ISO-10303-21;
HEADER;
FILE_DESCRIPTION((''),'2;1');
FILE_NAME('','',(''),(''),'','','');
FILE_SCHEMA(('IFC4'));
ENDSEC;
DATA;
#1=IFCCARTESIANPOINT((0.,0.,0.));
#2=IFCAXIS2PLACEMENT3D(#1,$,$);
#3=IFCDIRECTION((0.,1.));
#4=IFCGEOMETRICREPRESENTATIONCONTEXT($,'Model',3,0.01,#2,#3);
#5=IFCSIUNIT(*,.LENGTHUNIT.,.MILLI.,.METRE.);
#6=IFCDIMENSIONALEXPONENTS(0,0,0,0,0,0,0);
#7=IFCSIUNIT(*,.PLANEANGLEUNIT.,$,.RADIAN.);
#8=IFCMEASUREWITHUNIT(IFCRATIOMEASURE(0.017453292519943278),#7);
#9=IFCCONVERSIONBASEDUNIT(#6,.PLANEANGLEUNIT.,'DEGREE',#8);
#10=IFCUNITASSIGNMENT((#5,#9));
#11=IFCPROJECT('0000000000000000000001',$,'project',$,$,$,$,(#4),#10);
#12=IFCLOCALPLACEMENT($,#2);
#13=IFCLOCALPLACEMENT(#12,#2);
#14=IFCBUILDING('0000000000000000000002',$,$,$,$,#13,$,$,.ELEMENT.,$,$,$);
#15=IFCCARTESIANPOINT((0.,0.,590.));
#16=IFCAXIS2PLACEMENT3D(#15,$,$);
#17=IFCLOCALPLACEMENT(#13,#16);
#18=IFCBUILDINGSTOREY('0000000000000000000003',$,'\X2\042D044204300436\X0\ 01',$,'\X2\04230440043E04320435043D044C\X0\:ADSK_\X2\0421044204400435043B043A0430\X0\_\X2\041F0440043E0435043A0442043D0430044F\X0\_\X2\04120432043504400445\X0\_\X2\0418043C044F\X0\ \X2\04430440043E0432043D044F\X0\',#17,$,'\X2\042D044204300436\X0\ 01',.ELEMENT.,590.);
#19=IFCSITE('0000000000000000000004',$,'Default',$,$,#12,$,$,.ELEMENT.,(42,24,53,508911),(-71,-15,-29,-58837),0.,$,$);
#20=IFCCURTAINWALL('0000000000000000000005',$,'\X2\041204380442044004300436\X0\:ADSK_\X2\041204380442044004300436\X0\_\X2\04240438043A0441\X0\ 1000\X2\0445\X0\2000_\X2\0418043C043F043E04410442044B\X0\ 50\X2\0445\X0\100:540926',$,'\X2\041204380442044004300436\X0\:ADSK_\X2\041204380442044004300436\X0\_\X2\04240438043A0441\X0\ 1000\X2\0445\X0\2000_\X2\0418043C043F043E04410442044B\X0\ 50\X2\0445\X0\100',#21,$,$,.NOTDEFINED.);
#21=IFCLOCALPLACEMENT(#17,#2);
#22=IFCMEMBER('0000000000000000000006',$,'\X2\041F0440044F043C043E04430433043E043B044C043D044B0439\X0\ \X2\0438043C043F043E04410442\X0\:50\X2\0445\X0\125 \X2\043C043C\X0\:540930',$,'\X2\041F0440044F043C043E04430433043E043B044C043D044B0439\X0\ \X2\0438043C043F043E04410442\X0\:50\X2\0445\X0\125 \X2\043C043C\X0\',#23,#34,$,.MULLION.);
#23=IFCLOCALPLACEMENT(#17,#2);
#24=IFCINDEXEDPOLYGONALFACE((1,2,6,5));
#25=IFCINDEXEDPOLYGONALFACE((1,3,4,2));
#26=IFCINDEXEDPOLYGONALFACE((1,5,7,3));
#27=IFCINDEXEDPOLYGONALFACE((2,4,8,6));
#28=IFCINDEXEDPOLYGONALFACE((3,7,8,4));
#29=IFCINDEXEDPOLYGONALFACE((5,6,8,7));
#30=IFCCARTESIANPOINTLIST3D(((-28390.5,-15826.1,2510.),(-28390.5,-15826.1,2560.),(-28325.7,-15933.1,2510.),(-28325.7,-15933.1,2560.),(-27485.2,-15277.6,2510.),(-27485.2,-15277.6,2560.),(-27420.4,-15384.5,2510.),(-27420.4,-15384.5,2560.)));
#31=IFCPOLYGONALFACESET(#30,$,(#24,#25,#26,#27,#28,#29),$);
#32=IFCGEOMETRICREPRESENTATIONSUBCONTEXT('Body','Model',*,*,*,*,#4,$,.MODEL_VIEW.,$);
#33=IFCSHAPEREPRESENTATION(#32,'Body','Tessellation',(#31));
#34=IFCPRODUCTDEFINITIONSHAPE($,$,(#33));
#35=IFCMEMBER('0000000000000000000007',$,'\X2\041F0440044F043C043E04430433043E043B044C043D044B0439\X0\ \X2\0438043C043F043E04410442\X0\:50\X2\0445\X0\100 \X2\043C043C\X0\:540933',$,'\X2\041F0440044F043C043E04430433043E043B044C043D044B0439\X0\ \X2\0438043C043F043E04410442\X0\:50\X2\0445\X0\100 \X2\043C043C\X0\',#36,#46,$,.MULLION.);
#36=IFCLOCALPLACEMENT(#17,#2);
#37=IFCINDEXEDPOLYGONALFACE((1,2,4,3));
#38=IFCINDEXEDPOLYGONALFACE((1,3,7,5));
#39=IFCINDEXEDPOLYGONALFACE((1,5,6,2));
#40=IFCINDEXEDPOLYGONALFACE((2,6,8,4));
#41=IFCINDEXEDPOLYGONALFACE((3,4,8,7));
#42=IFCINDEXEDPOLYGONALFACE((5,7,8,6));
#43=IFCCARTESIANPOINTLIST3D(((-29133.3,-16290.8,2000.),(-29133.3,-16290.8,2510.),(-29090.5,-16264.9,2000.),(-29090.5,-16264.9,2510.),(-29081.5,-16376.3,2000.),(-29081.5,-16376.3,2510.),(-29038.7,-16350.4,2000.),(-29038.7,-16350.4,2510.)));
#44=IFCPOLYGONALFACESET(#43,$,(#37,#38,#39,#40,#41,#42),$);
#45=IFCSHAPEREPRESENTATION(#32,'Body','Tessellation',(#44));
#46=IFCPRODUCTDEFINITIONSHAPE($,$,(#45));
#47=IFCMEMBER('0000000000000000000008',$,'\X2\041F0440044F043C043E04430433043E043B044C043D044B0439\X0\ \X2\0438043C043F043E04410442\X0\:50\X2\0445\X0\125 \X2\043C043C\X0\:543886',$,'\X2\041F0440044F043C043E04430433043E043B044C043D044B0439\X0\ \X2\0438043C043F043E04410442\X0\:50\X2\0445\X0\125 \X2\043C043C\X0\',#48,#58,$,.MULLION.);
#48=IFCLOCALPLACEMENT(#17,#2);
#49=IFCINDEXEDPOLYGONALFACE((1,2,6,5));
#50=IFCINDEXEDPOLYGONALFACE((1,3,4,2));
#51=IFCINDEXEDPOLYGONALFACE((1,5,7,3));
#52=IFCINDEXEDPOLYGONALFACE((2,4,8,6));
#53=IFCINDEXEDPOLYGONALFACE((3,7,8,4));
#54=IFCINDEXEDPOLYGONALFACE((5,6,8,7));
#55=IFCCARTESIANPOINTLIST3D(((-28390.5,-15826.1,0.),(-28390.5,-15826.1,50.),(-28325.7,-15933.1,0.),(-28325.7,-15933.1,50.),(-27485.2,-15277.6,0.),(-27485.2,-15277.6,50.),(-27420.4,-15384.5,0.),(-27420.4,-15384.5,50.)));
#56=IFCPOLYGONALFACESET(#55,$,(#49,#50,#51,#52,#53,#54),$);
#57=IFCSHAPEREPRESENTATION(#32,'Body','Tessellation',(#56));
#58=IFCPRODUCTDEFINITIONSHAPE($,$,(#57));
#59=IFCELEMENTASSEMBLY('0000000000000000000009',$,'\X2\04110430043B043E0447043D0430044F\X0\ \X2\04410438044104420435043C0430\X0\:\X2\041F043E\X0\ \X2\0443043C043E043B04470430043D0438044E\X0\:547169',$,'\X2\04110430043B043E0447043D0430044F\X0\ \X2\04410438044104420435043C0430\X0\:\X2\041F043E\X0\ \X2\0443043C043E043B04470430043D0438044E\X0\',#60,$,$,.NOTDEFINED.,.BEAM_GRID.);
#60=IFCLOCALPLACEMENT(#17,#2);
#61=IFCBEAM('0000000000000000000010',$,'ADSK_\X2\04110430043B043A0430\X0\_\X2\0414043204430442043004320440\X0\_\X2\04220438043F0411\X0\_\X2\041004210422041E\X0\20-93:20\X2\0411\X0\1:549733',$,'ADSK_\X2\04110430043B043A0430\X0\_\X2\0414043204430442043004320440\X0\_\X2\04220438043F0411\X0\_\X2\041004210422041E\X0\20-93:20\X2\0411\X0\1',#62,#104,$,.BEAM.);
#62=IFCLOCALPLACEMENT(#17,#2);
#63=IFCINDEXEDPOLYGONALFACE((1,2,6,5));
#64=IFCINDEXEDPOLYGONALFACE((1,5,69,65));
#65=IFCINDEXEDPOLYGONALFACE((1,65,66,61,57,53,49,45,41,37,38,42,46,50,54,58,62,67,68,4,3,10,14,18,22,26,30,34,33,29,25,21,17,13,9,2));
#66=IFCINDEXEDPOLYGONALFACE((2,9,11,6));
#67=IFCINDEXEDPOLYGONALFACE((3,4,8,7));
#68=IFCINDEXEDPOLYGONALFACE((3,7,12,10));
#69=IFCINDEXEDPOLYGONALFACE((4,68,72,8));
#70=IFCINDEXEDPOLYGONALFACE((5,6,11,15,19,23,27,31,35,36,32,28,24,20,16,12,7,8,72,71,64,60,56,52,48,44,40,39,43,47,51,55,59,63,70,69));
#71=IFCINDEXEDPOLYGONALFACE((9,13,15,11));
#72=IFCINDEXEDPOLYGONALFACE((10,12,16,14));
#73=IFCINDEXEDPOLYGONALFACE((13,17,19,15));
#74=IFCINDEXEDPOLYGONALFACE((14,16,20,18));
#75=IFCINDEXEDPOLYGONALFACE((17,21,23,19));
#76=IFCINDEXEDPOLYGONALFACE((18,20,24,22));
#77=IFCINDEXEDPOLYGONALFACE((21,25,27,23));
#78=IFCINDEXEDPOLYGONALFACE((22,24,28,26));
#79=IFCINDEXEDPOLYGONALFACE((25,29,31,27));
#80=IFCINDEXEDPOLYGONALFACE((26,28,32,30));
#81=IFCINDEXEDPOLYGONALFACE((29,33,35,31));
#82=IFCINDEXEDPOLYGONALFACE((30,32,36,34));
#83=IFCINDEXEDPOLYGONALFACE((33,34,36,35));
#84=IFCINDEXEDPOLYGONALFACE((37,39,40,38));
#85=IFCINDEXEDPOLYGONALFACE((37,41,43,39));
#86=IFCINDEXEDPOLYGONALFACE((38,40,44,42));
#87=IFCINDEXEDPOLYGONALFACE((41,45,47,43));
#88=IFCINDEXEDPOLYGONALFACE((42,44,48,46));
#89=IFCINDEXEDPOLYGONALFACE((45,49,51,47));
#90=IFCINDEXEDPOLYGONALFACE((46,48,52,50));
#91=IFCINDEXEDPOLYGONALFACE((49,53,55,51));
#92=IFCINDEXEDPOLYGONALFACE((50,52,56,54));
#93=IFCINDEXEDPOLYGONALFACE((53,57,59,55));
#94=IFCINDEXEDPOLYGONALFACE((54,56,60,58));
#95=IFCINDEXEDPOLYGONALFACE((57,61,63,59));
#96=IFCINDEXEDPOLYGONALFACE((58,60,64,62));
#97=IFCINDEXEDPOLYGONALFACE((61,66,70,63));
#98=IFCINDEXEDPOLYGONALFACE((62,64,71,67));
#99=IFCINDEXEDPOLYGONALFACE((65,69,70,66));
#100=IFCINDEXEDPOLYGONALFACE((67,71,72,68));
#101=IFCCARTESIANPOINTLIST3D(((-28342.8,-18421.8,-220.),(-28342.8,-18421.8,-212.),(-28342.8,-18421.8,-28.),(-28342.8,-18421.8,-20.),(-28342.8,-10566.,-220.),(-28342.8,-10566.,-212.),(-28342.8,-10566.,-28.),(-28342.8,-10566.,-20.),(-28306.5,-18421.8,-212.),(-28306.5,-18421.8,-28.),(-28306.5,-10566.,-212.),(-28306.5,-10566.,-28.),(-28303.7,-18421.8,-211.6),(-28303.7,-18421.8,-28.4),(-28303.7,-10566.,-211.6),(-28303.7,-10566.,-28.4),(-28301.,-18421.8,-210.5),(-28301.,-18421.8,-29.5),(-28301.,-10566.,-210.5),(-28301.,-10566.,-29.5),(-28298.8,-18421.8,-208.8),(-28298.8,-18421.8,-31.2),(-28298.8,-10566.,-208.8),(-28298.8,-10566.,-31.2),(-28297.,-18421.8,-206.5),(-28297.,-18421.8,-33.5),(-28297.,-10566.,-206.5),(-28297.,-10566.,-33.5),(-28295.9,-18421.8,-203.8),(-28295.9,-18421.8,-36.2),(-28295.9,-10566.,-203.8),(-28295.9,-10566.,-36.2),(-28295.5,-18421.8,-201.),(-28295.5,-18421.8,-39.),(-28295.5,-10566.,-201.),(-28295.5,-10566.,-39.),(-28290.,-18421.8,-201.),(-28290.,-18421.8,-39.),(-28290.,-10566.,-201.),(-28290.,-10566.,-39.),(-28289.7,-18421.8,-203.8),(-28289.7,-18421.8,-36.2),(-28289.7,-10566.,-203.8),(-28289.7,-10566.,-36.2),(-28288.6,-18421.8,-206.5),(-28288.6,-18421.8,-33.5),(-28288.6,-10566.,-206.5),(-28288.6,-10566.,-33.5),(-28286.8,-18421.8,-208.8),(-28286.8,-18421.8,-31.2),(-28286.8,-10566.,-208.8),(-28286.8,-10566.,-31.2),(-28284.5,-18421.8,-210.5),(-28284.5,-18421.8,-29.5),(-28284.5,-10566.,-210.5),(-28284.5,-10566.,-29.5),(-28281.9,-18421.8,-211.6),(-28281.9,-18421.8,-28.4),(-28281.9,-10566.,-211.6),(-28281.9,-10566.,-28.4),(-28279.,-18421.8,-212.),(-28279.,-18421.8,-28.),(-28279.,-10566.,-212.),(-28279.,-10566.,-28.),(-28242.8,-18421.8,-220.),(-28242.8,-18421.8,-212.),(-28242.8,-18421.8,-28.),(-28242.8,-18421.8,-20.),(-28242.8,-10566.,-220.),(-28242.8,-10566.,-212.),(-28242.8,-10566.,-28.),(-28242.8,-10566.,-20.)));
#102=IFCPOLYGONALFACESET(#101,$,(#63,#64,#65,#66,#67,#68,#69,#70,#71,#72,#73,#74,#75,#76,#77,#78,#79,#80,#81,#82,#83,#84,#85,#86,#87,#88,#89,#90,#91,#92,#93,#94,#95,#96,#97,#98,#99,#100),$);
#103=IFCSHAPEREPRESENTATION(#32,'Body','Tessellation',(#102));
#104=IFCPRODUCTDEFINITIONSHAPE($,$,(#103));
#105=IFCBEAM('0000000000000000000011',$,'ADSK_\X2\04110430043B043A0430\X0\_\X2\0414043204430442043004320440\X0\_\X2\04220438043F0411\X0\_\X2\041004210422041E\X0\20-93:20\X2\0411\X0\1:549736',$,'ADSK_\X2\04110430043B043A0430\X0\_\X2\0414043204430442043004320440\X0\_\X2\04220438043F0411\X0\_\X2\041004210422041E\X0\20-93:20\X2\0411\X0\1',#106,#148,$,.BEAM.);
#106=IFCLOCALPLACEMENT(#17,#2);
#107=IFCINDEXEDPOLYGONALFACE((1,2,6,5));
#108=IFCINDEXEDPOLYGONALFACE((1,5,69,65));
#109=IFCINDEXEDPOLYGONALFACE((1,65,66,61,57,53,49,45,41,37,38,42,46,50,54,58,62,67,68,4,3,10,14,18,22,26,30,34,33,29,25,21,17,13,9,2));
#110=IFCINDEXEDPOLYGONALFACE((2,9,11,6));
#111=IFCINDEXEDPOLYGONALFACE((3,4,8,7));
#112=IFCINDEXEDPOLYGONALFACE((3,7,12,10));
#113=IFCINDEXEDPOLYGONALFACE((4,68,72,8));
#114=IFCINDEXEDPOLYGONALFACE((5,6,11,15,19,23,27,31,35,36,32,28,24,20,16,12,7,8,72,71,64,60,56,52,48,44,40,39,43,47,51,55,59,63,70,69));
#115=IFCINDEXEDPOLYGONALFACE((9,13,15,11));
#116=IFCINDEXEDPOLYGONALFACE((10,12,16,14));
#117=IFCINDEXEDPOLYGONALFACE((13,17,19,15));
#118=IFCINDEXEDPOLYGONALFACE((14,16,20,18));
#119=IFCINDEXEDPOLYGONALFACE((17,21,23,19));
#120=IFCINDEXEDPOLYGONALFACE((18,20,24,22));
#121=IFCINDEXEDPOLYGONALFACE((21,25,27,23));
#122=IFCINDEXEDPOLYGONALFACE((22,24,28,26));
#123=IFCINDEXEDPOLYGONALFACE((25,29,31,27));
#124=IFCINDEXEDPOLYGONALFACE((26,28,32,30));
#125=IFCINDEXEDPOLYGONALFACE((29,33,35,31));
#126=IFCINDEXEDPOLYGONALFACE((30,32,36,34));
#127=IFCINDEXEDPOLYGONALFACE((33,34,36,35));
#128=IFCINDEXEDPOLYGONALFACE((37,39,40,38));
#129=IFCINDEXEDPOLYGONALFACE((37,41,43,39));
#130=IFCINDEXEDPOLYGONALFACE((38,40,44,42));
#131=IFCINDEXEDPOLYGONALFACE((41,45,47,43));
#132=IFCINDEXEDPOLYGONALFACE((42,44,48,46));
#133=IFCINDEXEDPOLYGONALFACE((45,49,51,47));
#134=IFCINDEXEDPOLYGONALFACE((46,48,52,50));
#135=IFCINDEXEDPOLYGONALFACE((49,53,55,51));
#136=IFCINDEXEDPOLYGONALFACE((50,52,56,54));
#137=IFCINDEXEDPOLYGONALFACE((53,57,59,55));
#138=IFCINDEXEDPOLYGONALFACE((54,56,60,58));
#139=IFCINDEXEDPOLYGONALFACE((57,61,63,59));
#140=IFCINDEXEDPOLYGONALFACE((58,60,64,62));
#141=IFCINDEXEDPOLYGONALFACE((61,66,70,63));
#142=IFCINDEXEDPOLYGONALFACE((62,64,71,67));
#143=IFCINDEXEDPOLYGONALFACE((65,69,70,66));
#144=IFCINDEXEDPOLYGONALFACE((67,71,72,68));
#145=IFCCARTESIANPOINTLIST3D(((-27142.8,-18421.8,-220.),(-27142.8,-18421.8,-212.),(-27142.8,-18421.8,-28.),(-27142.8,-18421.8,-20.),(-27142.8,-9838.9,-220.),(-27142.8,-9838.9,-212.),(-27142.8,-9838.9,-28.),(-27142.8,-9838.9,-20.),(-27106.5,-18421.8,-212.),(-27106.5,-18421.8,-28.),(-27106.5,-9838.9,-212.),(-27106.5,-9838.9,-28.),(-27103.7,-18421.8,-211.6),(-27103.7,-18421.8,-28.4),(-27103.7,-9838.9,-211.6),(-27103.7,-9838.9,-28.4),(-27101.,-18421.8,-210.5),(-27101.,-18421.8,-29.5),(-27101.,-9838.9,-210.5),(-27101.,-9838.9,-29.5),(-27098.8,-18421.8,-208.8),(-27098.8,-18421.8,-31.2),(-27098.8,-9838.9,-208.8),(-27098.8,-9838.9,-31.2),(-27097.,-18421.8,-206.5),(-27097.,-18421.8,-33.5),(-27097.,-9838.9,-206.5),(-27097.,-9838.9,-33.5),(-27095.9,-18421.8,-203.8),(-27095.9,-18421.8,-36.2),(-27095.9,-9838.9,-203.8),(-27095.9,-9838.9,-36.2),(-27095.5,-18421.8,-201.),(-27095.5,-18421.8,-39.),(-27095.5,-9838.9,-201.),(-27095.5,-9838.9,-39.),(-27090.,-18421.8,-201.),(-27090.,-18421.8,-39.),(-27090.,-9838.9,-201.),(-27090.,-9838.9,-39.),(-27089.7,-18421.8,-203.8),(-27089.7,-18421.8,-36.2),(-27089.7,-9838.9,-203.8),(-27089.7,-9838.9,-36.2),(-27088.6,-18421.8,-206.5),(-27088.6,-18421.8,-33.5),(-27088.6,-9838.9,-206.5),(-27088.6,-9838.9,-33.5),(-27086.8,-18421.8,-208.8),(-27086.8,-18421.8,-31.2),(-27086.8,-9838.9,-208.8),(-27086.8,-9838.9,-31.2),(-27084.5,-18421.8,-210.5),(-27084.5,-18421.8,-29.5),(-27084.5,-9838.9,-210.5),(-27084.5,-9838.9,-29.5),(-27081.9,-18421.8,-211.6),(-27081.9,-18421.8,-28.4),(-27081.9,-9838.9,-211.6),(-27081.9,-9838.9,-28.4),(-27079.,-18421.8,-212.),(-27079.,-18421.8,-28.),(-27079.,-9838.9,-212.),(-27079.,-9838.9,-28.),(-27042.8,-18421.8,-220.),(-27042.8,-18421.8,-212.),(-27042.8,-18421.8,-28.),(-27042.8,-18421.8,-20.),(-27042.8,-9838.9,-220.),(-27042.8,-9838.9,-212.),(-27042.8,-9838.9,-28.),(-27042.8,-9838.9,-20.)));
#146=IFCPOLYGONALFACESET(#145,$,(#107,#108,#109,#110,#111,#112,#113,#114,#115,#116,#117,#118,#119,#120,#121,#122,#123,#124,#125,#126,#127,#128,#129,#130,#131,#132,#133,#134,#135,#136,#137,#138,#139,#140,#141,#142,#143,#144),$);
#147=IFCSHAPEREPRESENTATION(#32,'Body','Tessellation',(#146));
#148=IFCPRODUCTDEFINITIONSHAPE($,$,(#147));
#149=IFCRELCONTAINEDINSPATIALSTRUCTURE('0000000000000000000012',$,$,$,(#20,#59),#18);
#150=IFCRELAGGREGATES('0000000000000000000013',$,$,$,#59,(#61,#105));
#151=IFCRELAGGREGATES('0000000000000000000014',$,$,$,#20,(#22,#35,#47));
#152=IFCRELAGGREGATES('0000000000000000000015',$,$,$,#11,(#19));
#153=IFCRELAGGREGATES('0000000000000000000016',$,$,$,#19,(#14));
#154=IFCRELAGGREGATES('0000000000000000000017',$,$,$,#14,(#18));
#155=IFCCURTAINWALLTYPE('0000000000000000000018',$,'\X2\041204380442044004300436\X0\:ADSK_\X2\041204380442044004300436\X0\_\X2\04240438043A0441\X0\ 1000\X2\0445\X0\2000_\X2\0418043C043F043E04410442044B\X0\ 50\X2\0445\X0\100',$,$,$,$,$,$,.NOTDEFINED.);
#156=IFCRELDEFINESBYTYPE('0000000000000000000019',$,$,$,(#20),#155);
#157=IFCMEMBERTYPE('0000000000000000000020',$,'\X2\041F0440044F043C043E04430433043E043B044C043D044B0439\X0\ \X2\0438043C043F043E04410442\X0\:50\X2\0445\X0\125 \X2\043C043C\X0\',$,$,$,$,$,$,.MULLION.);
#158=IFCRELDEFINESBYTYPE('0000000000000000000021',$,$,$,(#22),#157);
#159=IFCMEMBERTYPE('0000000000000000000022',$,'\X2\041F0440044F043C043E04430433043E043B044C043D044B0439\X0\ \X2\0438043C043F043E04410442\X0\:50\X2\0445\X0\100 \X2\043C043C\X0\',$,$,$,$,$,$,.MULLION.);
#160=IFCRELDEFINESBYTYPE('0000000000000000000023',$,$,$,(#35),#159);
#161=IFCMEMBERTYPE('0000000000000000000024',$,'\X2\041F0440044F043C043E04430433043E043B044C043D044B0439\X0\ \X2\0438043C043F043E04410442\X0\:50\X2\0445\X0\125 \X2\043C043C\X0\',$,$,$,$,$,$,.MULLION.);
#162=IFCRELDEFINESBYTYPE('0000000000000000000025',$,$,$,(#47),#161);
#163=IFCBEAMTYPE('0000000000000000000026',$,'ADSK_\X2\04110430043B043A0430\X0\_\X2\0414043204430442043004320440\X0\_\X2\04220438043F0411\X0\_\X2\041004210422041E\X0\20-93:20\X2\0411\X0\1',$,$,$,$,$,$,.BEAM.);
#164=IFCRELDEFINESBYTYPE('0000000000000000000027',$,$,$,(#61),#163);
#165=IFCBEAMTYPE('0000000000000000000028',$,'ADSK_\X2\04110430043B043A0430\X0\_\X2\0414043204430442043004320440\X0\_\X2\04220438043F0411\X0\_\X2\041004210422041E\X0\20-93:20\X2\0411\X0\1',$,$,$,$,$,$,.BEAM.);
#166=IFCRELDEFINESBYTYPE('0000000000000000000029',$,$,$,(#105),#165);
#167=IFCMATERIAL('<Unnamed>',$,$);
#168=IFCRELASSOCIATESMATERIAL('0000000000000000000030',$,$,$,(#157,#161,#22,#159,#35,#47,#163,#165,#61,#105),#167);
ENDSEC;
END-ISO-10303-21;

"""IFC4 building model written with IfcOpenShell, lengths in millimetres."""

from ifc_helpers import new_model, entity, si_unit, converted_unit, direction, frame, frame_2d, origin, origin_2d_with_axis, place, context, subcontext, project, spatial, polyline, circle_curve, parameter, trimmed, segment, composite_curve, rectangle, i_section, outline, extrude, source, transform, mapped, material, material_profile, profile_set, profile_usage, type_object, type_shapes, element, aggregate, save


model = new_model("IFC4")

# Units and contexts
model_context = context("Model", 3, precision=0.01, world=origin(), true_north=direction((0.0, 1.0)))
body_context = subcontext(model_context, "Body", "Model", "MODEL_VIEW")
ifc_project = project(units=[si_unit("LENGTHUNIT", "METRE", prefix="MILLI"), converted_unit("PLANEANGLEUNIT", "DEGREE", entity("IfcRatioMeasure", 0.017453292519943278), si_unit("PLANEANGLEUNIT", "RADIAN"), dimensions=[0, 0, 0, 0, 0, 0, 0])], contexts=[model_context])

# Site, building, storey
site_placement = place(None, origin())
site = spatial("IfcSite", under=ifc_project, at=site_placement, Name="Default", CompositionType="ELEMENT", RefLatitude=(42, 24, 53, 508911), RefLongitude=(-71, -15, -29, -58837), RefElevation=0.0)
building_placement = place(site_placement, origin())
building = spatial("IfcBuilding", under=site, at=building_placement, CompositionType="ELEMENT")
storey_placement = place(building_placement, frame((0.0, 0.0, 590.0)))
storey = spatial("IfcBuildingStorey", under=building, at=storey_placement, Name="Этаж 01", ObjectType="Уровень:ADSK_Стрелка_Проектная_Вверх_Имя уровня", LongName="Этаж 01", CompositionType="ELEMENT", Elevation=590.0)

# Curtain wall, members
curtain_wall_type = type_object("IfcCurtainWallType", Name="Витраж:ADSK_Витраж_Фикс 1000х2000_Импосты 50х100", PredefinedType="NOTDEFINED")
curtain_wall_placement = place(storey_placement, frame((0.0, 0.0, -590.0)))
curtain_wall = element("IfcCurtainWall", 1, at=curtain_wall_placement, inside=storey, type_object=curtain_wall_type, Name="Витраж:ADSK_Витраж_Фикс 1000х2000_Импосты 50х100:540926", ObjectType="Витраж:ADSK_Витраж_Фикс 1000х2000_Импосты 50х100", PredefinedType="NOTDEFINED")
ifc_material_1 = material(Name="<Unnamed>")
ifc_material_profile_1 = material_profile(ifc_material_1, outline(composite_curve([segment(polyline([(0.0, 62.5, -1058.5), (0.0, -62.5, -1058.5)]), True, "CONTINUOUS"), segment(polyline([(0.0, -62.5, -1058.5), (-50.0, -62.5, -1058.5)]), True, "CONTINUOUS"), segment(polyline([(-50.0, -62.5, -1058.5), (-50.0, 62.5, -1058.5)]), True, "CONTINUOUS"), segment(polyline([(-50.0, 62.5, -1058.5), (0.0, 62.5, -1058.5)]), True, "CONTINUOUS")], self_intersect=False), kind="CURVE"), Name="50х125 мм")
ifc_profile_set_1 = profile_set([ifc_material_profile_1], Name="50х125 мм")
ifc_profile_usage_1 = profile_usage(ifc_profile_set_1)
member_type_1 = type_object("IfcMemberType", Name="Прямоугольный импост:50х125 мм", PredefinedType="MULLION", material=ifc_profile_set_1)
shared_shape_1 = source(origin(), body_context, "Body", "SweptSolid", [
    extrude(rectangle(XDim=125.0, YDim=50.0, at=origin_2d_with_axis()), frame((-25.0, 0.0, -1058.5), z_axis=(0.0, 0.0, 1.0), x_axis=(0.0, -1.0, 0.0)), (0.0, 0.0, 1.0), 1058.5),
])
type_shapes(member_type_1, [shared_shape_1])
member_1_placement = place(curtain_wall_placement, frame((-27452.8, -15331.1, 3150.0), z_axis=(0.855267, 0.518188, 0.0), x_axis=(0.0, 0.0, 1.0)))
member_1 = element("IfcMember", 2, at=member_1_placement, type_object=member_type_1, material=ifc_profile_usage_1, Name="Прямоугольный импост:50х125 мм:540930", ObjectType="Прямоугольный импост:50х125 мм", PredefinedType="MULLION", context=body_context, shape_type="MappedRepresentation", body=[
    mapped(shared_shape_1, transform((0.0, 0.0, 0.0), scale=1.0)),
])
ifc_material_profile_2 = material_profile(ifc_material_1, outline(composite_curve([segment(polyline([(0.0, 50.0, -510.0), (0.0, -50.0, -510.0)]), True, "CONTINUOUS"), segment(polyline([(0.0, -50.0, -510.0), (-50.0, -50.0, -510.0)]), True, "CONTINUOUS"), segment(polyline([(-50.0, -50.0, -510.0), (-50.0, 50.0, -510.0)]), True, "CONTINUOUS"), segment(polyline([(-50.0, 50.0, -510.0), (0.0, 50.0, -510.0)]), True, "CONTINUOUS")], self_intersect=False), kind="CURVE"), Name="50х100 мм")
ifc_profile_set_2 = profile_set([ifc_material_profile_2], Name="50х100 мм")
ifc_profile_usage_2 = profile_usage(ifc_profile_set_2)
member_type_2 = type_object("IfcMemberType", Name="Прямоугольный импост:50х100 мм", PredefinedType="MULLION", material=ifc_profile_set_2)
shared_shape_2 = source(origin(), body_context, "Body", "SweptSolid", [
    extrude(rectangle(XDim=100.0, YDim=50.0, at=origin_2d_with_axis()), frame((-25.0, 0.0, -510.0), z_axis=(0.0, 0.0, 1.0), x_axis=(0.0, -1.0, 0.0)), (0.0, 0.0, 1.0), 510.0),
])
type_shapes(member_type_2, [shared_shape_2])
member_2_placement = place(curtain_wall_placement, frame((-29107.4, -16333.6, 3100.0), z_axis=(0.0, 0.0, 1.0), x_axis=(-0.855267, -0.518188, 0.0)))
member_2 = element("IfcMember", 3, at=member_2_placement, type_object=member_type_2, material=ifc_profile_usage_2, Name="Прямоугольный импост:50х100 мм:540933", ObjectType="Прямоугольный импост:50х100 мм", PredefinedType="MULLION", context=body_context, shape_type="MappedRepresentation", body=[
    mapped(shared_shape_2, transform((0.0, 0.0, 0.0), scale=1.0)),
])
ifc_profile_usage_3 = profile_usage(ifc_profile_set_1)
member_type_3 = type_object("IfcMemberType", Name="Прямоугольный импост:50х125 мм", PredefinedType="MULLION", material=ifc_profile_set_1)
shared_shape_3 = source(origin(), body_context, "Body", "SweptSolid", [
    extrude(rectangle(XDim=125.0, YDim=50.0, at=origin_2d_with_axis()), frame((-25.0, 0.0, -1058.5), z_axis=(0.0, 0.0, 1.0), x_axis=(0.0, -1.0, 0.0)), (0.0, 0.0, 1.0), 1058.5),
])
type_shapes(member_type_3, [shared_shape_3])
member_3_placement = place(curtain_wall_placement, frame((-28358.1, -15879.6, 590.0), z_axis=(-0.855267, -0.518188, 0.0), x_axis=(0.0, 0.0, -1.0)))
member_3 = element("IfcMember", 4, at=member_3_placement, type_object=member_type_3, material=ifc_profile_usage_3, Name="Прямоугольный импост:50х125 мм:543886", ObjectType="Прямоугольный импост:50х125 мм", PredefinedType="MULLION", context=body_context, shape_type="MappedRepresentation", body=[
    mapped(shared_shape_3, transform((0.0, 0.0, 0.0), scale=1.0)),
])

# Element assembly, beams
assembly_placement = place(storey_placement, origin())
assembly = element("IfcElementAssembly", 5, at=assembly_placement, inside=storey, Name="Балочная система:По умолчанию:547169", ObjectType="Балочная система:По умолчанию", AssemblyPlace="NOTDEFINED", PredefinedType="BEAM_GRID")
ifc_material_profile_3 = material_profile(ifc_material_1, outline(composite_curve([segment(polyline([(13.7, -192.0, 0.0), (50.0, -192.0, 0.0)]), True, "CONTINUOUS"), segment(polyline([(50.0, -192.0, 0.0), (50.0, -200.0, 0.0)]), True, "CONTINUOUS"), segment(polyline([(50.0, -200.0, 0.0), (-50.0, -200.0, 0.0)]), True, "CONTINUOUS"), segment(polyline([(-50.0, -200.0, 0.0), (-50.0, -192.0, 0.0)]), True, "CONTINUOUS"), segment(polyline([(-50.0, -192.0, 0.0), (-13.8, -192.0, 0.0)]), True, "CONTINUOUS"), segment(trimmed(circle_curve(frame((-13.8, -181.0, 0.0), z_axis=(0.0, 0.0, 1.0), x_axis=(-1.0, 0.0, 0.0)), 11.0), [parameter(90.0)], [parameter(180.0)], True, "PARAMETER"), True, "CONTINUOUS"), segment(polyline([(-2.8, -181.0, 0.0), (-2.8, -19.0, 0.0)]), True, "CONTINUOUS"), segment(trimmed(circle_curve(frame((-13.8, -19.0, 0.0), z_axis=(0.0, 0.0, 1.0), x_axis=(-1.0, 0.0, 0.0)), 11.0), [parameter(180.0)], [parameter(270.0)], True, "PARAMETER"), True, "CONTINUOUS"), segment(polyline([(-13.8, -8.0, 0.0), (-50.0, -8.0, 0.0)]), True, "CONTINUOUS"), segment(polyline([(-50.0, -8.0, 0.0), (-50.0, 0.0, 0.0)]), True, "CONTINUOUS"), segment(polyline([(-50.0, 0.0, 0.0), (50.0, 0.0, 0.0)]), True, "CONTINUOUS"), segment(polyline([(50.0, 0.0, 0.0), (50.0, -8.0, 0.0)]), True, "CONTINUOUS"), segment(polyline([(50.0, -8.0, 0.0), (13.7, -8.0, 0.0)]), True, "CONTINUOUS"), segment(trimmed(circle_curve(frame((13.7, -19.0, 0.0), z_axis=(0.0, 0.0, 1.0), x_axis=(-1.0, 0.0, 0.0)), 11.0), [parameter(270.0)], [parameter(0.0)], True, "PARAMETER"), True, "CONTINUOUS"), segment(polyline([(2.7, -19.0, 0.0), (2.7, -181.0, 0.0)]), True, "CONTINUOUS"), segment(trimmed(circle_curve(frame((13.7, -181.0, 0.0), z_axis=(0.0, 0.0, 1.0), x_axis=(-1.0, 0.0, 0.0)), 11.0), [parameter(0.0)], [parameter(90.0)], True, "PARAMETER"), True, "CONTINUOUS")], self_intersect=False), kind="CURVE"), Name="20Б1")
ifc_profile_set_3 = profile_set([ifc_material_profile_3], Name="20Б1")
ifc_profile_usage_4 = profile_usage(ifc_profile_set_3, cardinal=8)
beam_type_1 = type_object("IfcBeamType", Name="ADSK_Балка_Двутавр_ТипБ_АСТО20-93:20Б1", PredefinedType="BEAM", material=ifc_profile_set_3)
shared_shape_4 = source(origin(), body_context, "Body", "SweptSolid", [
    extrude(i_section(OverallWidth=100.0, OverallDepth=200.0, WebThickness=5.5, FlangeThickness=8.0, FilletRadius=11.0, at=frame_2d((0.0, 0.0), x_axis=(0.0, 1.0))), frame((-3927.9, 0.0, -100.0), z_axis=(1.0, 0.0, 0.0), x_axis=(0.0, 0.0, -1.0)), (0.0, 0.0, 1.0), 7855.8),
])
type_shapes(beam_type_1, [shared_shape_4])
beam_1_placement = place(assembly_placement, frame((-28292.8, -14493.9, -20.0), z_axis=(0.0, 0.0, 1.0), x_axis=(0.0, 1.0, 0.0)))
beam_1 = element("IfcBeam", 6, at=beam_1_placement, type_object=beam_type_1, material=ifc_profile_usage_4, Name="ADSK_Балка_Двутавр_ТипБ_АСТО20-93:20Б1:549733", ObjectType="ADSK_Балка_Двутавр_ТипБ_АСТО20-93:20Б1", PredefinedType="BEAM", context=body_context, shape_type="MappedRepresentation", body=[
    mapped(shared_shape_4, transform((0.0, 0.0, 0.0), scale=1.0)),
])
ifc_profile_usage_5 = profile_usage(ifc_profile_set_3, cardinal=8)
beam_type_2 = type_object("IfcBeamType", Name="ADSK_Балка_Двутавр_ТипБ_АСТО20-93:20Б1", PredefinedType="BEAM", material=ifc_profile_set_3)
shared_shape_5 = source(origin(), body_context, "Body", "SweptSolid", [
    extrude(i_section(OverallWidth=100.0, OverallDepth=200.0, WebThickness=5.5, FlangeThickness=8.0, FilletRadius=11.0, at=frame_2d((0.0, 0.0), x_axis=(0.0, 1.0))), frame((-4291.4, 0.0, -100.0), z_axis=(1.0, 0.0, 0.0), x_axis=(0.0, 0.0, -1.0)), (0.0, 0.0, 1.0), 8582.9),
])
type_shapes(beam_type_2, [shared_shape_5])
beam_2_placement = place(assembly_placement, frame((-27092.8, -14130.4, -20.0), z_axis=(0.0, 0.0, 1.0), x_axis=(0.0, 1.0, 0.0)))
beam_2 = element("IfcBeam", 7, at=beam_2_placement, type_object=beam_type_2, material=ifc_profile_usage_5, Name="ADSK_Балка_Двутавр_ТипБ_АСТО20-93:20Б1:549736", ObjectType="ADSK_Балка_Двутавр_ТипБ_АСТО20-93:20Б1", PredefinedType="BEAM", context=body_context, shape_type="MappedRepresentation", body=[
    mapped(shared_shape_5, transform((0.0, 0.0, 0.0), scale=1.0)),
])
aggregate(assembly, [beam_1, beam_2])

aggregate(curtain_wall, [member_1, member_2, member_3])

save(model, "model.ifc")
